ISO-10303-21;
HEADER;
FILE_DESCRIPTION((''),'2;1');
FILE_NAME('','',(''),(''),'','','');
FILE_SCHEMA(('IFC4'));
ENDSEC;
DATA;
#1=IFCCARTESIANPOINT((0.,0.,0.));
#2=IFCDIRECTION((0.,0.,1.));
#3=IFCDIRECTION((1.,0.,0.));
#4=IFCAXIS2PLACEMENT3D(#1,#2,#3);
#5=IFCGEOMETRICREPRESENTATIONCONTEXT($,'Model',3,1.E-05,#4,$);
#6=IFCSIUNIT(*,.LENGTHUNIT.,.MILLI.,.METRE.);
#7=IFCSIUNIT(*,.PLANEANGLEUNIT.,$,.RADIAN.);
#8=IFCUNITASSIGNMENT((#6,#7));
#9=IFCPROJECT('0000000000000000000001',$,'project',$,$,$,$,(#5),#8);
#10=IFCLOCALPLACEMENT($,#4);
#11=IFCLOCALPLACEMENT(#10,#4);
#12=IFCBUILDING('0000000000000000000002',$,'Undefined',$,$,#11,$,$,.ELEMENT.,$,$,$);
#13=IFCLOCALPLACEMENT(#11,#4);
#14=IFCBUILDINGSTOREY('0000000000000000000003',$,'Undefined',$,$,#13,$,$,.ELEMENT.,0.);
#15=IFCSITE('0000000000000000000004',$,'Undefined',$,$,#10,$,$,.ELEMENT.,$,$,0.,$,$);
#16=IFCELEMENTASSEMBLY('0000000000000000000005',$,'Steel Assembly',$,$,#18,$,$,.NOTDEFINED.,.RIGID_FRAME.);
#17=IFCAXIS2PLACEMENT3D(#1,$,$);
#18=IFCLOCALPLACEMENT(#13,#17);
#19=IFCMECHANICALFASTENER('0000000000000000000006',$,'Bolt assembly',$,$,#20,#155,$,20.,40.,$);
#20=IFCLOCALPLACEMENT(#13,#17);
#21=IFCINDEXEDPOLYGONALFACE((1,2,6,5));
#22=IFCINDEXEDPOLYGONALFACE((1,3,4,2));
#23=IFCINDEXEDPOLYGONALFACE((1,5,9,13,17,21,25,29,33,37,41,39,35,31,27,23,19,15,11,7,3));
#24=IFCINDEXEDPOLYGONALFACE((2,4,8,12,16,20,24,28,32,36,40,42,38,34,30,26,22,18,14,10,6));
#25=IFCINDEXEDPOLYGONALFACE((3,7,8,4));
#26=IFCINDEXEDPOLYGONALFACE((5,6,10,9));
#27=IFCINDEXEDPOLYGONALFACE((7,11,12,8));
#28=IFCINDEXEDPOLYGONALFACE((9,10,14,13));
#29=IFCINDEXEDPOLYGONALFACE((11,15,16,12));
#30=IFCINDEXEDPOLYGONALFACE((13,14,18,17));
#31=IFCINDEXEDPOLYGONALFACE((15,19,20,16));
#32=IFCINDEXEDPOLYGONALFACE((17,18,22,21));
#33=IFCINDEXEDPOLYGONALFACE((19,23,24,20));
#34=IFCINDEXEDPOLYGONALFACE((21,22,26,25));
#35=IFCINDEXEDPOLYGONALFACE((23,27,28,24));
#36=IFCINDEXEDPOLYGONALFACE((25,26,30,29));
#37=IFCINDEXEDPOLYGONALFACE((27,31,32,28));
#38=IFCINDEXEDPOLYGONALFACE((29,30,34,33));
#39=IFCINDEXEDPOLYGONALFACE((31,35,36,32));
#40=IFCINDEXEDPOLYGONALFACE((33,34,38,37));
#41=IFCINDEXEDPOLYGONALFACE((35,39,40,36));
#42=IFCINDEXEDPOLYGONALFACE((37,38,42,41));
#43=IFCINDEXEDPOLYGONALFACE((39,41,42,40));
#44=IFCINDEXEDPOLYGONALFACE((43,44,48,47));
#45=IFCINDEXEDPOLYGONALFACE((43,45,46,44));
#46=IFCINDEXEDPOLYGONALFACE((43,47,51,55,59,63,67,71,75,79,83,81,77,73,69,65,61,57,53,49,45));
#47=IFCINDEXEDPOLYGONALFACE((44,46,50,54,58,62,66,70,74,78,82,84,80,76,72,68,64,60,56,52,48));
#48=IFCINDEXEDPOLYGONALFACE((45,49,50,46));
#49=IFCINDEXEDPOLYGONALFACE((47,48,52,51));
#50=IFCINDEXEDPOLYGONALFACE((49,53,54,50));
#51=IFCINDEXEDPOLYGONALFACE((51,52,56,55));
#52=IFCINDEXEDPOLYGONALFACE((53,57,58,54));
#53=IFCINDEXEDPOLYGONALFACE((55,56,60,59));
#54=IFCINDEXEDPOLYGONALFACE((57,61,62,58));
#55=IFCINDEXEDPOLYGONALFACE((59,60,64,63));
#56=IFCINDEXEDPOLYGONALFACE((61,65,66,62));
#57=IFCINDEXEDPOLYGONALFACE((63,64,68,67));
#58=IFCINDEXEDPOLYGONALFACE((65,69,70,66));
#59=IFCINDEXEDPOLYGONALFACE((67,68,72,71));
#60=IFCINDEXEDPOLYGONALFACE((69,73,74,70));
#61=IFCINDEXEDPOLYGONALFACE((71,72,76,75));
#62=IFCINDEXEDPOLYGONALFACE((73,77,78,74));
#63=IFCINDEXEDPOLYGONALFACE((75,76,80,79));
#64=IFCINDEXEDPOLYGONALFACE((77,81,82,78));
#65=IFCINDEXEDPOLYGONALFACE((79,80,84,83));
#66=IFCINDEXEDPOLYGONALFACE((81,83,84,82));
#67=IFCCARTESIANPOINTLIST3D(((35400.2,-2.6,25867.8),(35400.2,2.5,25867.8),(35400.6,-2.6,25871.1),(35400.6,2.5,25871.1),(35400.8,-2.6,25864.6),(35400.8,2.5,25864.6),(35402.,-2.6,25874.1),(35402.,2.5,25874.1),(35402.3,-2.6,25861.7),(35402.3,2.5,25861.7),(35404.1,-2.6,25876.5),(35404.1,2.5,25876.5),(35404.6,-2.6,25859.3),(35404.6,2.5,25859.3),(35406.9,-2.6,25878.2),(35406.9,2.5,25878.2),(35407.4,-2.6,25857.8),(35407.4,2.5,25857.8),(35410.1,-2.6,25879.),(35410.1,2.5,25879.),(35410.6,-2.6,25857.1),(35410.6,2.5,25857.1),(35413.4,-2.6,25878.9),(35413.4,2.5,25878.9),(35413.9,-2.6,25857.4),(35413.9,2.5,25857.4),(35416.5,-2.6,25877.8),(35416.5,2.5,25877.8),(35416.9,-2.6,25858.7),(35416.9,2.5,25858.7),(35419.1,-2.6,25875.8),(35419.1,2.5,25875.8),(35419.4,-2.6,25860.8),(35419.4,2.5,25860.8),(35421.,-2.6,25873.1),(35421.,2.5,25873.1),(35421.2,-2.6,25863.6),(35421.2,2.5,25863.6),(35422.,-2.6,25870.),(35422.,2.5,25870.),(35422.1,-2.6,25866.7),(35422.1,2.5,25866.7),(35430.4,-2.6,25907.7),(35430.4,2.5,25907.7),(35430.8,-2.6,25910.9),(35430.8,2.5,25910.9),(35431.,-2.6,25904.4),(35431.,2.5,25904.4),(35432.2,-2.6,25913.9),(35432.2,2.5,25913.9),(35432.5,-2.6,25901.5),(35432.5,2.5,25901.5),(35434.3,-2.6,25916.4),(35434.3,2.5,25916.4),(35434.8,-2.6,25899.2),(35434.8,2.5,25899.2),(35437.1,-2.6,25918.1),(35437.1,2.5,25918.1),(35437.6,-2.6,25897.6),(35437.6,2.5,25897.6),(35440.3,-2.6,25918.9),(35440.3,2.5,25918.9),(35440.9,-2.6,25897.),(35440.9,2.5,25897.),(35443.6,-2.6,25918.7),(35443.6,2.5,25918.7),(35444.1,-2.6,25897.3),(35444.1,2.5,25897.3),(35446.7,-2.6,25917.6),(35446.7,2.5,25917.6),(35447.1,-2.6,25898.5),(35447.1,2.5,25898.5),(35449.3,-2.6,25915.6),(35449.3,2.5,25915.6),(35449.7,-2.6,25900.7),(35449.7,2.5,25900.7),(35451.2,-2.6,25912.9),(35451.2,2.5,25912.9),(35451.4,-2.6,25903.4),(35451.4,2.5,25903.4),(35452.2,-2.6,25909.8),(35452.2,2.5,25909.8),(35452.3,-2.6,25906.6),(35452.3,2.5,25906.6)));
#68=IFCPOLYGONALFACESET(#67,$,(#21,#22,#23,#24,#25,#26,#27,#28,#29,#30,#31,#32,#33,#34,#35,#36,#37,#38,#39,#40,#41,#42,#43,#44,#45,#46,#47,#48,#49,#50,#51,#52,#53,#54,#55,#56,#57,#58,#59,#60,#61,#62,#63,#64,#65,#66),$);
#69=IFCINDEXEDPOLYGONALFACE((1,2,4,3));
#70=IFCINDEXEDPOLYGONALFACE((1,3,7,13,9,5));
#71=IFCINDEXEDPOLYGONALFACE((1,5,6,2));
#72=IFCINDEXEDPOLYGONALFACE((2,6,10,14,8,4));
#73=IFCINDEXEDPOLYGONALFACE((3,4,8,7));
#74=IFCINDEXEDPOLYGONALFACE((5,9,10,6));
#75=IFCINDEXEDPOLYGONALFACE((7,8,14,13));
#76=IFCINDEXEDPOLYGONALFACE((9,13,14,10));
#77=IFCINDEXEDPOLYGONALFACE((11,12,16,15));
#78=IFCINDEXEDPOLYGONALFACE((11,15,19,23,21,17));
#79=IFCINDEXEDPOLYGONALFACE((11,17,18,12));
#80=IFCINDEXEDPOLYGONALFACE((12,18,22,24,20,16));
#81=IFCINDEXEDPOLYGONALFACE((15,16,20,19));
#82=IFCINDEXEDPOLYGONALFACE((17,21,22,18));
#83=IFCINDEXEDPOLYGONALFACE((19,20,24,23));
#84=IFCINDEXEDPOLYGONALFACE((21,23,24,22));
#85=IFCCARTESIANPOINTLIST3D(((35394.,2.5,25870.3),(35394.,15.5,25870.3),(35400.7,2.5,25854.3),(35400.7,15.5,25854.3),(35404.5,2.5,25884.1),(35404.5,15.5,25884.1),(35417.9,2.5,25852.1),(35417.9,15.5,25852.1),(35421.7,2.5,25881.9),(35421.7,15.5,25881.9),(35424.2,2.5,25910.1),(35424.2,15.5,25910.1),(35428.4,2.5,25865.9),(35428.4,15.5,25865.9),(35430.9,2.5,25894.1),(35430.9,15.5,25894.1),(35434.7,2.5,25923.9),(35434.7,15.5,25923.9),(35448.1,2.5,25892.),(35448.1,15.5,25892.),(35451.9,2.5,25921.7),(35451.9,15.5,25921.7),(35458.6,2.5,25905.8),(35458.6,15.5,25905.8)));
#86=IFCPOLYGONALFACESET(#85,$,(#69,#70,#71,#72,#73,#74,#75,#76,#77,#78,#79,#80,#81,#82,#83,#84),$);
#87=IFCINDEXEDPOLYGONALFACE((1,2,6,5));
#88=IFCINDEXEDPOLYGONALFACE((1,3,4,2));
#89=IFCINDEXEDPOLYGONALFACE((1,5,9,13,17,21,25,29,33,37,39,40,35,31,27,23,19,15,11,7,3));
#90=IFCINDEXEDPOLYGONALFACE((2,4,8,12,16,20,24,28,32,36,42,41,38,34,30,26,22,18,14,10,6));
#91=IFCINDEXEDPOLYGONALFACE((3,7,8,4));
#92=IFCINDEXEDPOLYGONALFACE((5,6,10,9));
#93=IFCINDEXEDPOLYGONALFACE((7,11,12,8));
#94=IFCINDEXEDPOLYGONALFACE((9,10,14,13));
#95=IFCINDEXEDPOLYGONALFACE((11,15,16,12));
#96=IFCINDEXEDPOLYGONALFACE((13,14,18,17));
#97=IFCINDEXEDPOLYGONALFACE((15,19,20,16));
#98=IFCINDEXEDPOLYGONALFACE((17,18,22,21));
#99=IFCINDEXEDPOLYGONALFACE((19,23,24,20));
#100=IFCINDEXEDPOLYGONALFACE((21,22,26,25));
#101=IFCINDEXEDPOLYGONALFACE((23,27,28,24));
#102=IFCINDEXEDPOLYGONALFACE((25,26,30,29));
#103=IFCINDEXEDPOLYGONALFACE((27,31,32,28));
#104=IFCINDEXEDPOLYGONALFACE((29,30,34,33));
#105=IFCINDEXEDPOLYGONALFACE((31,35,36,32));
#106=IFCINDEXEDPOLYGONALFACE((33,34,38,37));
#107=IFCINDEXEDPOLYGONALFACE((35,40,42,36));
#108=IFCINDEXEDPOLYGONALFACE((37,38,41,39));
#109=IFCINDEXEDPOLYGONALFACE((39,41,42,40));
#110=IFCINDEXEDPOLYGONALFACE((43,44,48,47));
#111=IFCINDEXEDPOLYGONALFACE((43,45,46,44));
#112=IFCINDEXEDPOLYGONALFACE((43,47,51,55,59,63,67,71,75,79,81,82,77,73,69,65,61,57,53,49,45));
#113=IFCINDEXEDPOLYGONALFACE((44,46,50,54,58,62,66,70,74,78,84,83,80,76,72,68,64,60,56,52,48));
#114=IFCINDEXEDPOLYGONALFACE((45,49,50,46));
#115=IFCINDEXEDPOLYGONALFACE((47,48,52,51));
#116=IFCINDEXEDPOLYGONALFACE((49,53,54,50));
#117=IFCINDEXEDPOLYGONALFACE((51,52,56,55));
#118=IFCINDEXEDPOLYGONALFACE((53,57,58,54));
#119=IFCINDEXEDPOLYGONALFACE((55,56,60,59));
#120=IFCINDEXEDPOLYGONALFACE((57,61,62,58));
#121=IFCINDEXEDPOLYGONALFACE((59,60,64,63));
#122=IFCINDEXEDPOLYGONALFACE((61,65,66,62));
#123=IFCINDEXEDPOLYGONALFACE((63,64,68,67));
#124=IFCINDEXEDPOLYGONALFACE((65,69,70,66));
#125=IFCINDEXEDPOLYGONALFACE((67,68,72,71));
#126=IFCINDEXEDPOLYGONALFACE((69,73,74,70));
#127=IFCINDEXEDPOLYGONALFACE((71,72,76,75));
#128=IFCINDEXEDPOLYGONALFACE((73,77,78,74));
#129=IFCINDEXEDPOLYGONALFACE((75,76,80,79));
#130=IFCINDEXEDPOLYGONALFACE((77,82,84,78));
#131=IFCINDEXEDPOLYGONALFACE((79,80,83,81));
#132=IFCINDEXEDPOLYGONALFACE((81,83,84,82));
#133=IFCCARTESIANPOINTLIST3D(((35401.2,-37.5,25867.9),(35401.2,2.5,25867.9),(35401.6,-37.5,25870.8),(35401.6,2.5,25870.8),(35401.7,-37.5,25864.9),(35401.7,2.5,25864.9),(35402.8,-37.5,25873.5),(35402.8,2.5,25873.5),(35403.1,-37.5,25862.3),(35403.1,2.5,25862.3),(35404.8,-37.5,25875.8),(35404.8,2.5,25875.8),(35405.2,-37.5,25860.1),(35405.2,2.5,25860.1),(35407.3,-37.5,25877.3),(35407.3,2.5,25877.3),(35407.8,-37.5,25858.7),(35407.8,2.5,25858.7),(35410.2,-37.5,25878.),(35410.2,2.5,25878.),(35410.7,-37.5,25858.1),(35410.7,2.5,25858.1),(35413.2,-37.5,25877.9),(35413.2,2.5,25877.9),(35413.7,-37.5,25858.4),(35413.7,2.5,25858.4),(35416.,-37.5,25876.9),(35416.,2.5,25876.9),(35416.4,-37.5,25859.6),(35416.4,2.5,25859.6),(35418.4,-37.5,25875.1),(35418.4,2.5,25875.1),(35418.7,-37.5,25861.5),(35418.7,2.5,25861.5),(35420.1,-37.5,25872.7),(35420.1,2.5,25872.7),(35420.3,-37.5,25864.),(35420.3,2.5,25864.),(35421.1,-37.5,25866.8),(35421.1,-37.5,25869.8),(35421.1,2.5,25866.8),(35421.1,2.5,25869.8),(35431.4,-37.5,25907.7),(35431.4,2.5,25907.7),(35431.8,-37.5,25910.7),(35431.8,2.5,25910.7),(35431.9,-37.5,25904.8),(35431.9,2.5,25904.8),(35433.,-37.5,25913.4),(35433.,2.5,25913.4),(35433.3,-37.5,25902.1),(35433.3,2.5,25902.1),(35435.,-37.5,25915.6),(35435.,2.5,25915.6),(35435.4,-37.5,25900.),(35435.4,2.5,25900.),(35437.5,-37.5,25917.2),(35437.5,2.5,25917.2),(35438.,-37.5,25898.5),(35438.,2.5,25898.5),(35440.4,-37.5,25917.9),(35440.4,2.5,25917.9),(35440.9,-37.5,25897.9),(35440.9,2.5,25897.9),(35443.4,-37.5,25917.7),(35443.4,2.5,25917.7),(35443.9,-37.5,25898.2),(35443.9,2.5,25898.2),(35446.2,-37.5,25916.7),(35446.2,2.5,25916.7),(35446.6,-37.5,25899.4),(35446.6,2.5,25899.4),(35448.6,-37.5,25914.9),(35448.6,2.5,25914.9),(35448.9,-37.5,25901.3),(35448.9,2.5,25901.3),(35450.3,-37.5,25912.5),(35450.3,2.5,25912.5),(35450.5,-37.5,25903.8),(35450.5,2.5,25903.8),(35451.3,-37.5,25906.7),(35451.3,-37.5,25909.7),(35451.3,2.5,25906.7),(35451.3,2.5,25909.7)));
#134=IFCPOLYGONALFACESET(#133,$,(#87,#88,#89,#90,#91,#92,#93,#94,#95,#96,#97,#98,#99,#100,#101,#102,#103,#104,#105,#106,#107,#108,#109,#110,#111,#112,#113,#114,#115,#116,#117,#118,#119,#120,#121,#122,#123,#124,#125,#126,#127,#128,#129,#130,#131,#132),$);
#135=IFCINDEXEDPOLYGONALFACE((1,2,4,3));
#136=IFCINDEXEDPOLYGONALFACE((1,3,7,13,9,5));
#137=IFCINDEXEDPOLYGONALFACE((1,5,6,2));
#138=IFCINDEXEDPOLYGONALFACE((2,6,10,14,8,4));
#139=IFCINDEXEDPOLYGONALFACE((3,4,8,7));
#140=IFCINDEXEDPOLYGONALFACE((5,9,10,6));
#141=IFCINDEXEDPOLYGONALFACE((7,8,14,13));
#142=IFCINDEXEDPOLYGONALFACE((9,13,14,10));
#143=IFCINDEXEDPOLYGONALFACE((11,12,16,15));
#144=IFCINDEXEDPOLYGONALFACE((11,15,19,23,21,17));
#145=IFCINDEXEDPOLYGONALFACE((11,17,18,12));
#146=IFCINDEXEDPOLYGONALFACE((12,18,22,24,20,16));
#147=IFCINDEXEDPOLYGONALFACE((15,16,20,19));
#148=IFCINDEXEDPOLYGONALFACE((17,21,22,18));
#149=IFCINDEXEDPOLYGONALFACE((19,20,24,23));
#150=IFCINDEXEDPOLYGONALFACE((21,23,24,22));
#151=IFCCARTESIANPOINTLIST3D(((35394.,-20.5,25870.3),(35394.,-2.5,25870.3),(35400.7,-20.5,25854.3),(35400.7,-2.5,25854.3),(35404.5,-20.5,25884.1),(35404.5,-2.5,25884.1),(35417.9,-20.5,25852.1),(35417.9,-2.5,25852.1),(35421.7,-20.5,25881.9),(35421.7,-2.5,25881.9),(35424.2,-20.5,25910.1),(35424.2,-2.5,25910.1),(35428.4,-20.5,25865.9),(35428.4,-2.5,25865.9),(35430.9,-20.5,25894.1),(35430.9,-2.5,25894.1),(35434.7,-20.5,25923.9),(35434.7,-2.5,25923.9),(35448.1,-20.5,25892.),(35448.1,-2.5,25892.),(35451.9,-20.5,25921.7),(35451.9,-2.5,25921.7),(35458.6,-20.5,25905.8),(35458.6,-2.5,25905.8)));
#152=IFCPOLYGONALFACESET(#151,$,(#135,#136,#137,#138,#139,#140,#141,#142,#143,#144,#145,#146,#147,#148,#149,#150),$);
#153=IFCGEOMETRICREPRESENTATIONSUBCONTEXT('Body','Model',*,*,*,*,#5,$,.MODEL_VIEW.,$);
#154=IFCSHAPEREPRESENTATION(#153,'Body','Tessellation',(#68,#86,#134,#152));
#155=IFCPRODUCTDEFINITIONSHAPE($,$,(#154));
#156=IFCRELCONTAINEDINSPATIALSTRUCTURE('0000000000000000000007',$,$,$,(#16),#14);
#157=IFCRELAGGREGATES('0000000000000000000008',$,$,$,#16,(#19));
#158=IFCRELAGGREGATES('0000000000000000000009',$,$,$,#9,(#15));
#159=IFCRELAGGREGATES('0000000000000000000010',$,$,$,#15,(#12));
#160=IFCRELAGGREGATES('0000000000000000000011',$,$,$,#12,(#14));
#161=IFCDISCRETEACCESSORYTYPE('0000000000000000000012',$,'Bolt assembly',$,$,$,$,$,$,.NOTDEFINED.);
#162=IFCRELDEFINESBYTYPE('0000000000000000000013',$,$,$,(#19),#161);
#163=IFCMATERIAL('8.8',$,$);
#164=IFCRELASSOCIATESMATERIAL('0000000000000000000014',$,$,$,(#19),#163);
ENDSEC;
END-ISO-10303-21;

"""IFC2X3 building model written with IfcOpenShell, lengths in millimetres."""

from ifc_helpers import new_model, si_unit, frame, origin_with_axes, origin_2d_with_axis, place, context, subcontext, project, spatial, polyline, circle, outline, extrude, source, transform, mapped, material, type_object, element, aggregate, save


model = new_model("IFC2X3")

# Units and contexts
model_context = context("Model", 3, precision=1e-05, world=origin_with_axes())
body_context = subcontext(model_context, "Body", "Model", "MODEL_VIEW")
ifc_project = project(units=[si_unit("LENGTHUNIT", "METRE", prefix="MILLI"), si_unit("PLANEANGLEUNIT", "RADIAN")], contexts=[model_context])

# Site, building, storey
site_placement = place(None, origin_with_axes())
site = spatial("IfcSite", under=ifc_project, at=site_placement, Name="Undefined", CompositionType="ELEMENT", RefElevation=0.0)
building_placement = place(site_placement, origin_with_axes())
building = spatial("IfcBuilding", under=site, at=building_placement, Name="Undefined", CompositionType="ELEMENT")
storey_placement = place(building_placement, origin_with_axes())
storey = spatial("IfcBuildingStorey", under=building, at=storey_placement, Name="Undefined", CompositionType="ELEMENT", Elevation=0.0)

# Element assembly
assembly_1_placement = place(storey_placement, origin_with_axes())
assembly_1 = element("IfcElementAssembly", 1, at=assembly_1_placement, inside=storey, Name="Steel Assembly", AssemblyPlace="NOTDEFINED", PredefinedType="RIGID_FRAME")

# Shared definitions
discrete_accessory_type_1 = type_object("IfcDiscreteAccessoryType", Name="Bolt assembly")
ifc_material_1 = material(Name="8.8")

# Mechanical fastener
shared_shape_1 = source(origin_with_axes(), body_context, "Body", "SweptSolid", [
    extrude(circle(Radius=11.0, at=origin_2d_with_axis()), frame((0.0, -2.5, 0.0), z_axis=(0.0, 1.0, 0.0), x_axis=(1.0, 0.0, 0.0)), (0.0, 0.0, 1.0), 5.1),
    extrude(outline(polyline([(17.3, 0.0), (8.7, 15.0), (-8.7, 15.0), (-17.3, 0.0), (-8.7, -15.0), (8.7, -15.0), (17.3, 0.0)])), frame((0.0, -15.5, 0.0), z_axis=(0.0, 1.0, 0.0), x_axis=(1.0, 0.0, 0.0)), (0.0, 0.0, 1.0), 13.0),
    extrude(circle(Radius=10.0, at=origin_2d_with_axis()), frame((0.0, -2.5, 0.0), z_axis=(0.0, 1.0, 0.0), x_axis=(1.0, 0.0, 0.0)), (0.0, 0.0, 1.0), 40.0),
    extrude(outline(polyline([(17.3, 0.0), (8.7, 15.0), (-8.7, 15.0), (-17.3, 0.0), (-8.7, -15.0), (8.7, -15.0), (17.3, 0.0)])), frame((0.0, 2.5, 0.0), z_axis=(0.0, 1.0, 0.0), x_axis=(1.0, 0.0, 0.0)), (0.0, 0.0, 1.0), 18.0),
])
mechanical_fastener_1_placement = place(assembly_1_placement, frame((35441.4, 0.0, 25907.9), z_axis=(-0.796808, 0.0, 0.604233), x_axis=(-0.604233, 0.0, -0.796808)))
mechanical_fastener_1 = element("IfcMechanicalFastener", 2, at=mechanical_fastener_1_placement, type_object=discrete_accessory_type_1, material=ifc_material_1, Name="Bolt assembly", NominalDiameter=20.0, NominalLength=40.0, context=body_context, shape_type="MappedRepresentation", body=[
    mapped(shared_shape_1, transform((0.0, 0.0, 0.0))),
    mapped(shared_shape_1, transform((50.0, 0.0, 0.0))),
])
aggregate(assembly_1, [mechanical_fastener_1])

save(model, "model.ifc")
